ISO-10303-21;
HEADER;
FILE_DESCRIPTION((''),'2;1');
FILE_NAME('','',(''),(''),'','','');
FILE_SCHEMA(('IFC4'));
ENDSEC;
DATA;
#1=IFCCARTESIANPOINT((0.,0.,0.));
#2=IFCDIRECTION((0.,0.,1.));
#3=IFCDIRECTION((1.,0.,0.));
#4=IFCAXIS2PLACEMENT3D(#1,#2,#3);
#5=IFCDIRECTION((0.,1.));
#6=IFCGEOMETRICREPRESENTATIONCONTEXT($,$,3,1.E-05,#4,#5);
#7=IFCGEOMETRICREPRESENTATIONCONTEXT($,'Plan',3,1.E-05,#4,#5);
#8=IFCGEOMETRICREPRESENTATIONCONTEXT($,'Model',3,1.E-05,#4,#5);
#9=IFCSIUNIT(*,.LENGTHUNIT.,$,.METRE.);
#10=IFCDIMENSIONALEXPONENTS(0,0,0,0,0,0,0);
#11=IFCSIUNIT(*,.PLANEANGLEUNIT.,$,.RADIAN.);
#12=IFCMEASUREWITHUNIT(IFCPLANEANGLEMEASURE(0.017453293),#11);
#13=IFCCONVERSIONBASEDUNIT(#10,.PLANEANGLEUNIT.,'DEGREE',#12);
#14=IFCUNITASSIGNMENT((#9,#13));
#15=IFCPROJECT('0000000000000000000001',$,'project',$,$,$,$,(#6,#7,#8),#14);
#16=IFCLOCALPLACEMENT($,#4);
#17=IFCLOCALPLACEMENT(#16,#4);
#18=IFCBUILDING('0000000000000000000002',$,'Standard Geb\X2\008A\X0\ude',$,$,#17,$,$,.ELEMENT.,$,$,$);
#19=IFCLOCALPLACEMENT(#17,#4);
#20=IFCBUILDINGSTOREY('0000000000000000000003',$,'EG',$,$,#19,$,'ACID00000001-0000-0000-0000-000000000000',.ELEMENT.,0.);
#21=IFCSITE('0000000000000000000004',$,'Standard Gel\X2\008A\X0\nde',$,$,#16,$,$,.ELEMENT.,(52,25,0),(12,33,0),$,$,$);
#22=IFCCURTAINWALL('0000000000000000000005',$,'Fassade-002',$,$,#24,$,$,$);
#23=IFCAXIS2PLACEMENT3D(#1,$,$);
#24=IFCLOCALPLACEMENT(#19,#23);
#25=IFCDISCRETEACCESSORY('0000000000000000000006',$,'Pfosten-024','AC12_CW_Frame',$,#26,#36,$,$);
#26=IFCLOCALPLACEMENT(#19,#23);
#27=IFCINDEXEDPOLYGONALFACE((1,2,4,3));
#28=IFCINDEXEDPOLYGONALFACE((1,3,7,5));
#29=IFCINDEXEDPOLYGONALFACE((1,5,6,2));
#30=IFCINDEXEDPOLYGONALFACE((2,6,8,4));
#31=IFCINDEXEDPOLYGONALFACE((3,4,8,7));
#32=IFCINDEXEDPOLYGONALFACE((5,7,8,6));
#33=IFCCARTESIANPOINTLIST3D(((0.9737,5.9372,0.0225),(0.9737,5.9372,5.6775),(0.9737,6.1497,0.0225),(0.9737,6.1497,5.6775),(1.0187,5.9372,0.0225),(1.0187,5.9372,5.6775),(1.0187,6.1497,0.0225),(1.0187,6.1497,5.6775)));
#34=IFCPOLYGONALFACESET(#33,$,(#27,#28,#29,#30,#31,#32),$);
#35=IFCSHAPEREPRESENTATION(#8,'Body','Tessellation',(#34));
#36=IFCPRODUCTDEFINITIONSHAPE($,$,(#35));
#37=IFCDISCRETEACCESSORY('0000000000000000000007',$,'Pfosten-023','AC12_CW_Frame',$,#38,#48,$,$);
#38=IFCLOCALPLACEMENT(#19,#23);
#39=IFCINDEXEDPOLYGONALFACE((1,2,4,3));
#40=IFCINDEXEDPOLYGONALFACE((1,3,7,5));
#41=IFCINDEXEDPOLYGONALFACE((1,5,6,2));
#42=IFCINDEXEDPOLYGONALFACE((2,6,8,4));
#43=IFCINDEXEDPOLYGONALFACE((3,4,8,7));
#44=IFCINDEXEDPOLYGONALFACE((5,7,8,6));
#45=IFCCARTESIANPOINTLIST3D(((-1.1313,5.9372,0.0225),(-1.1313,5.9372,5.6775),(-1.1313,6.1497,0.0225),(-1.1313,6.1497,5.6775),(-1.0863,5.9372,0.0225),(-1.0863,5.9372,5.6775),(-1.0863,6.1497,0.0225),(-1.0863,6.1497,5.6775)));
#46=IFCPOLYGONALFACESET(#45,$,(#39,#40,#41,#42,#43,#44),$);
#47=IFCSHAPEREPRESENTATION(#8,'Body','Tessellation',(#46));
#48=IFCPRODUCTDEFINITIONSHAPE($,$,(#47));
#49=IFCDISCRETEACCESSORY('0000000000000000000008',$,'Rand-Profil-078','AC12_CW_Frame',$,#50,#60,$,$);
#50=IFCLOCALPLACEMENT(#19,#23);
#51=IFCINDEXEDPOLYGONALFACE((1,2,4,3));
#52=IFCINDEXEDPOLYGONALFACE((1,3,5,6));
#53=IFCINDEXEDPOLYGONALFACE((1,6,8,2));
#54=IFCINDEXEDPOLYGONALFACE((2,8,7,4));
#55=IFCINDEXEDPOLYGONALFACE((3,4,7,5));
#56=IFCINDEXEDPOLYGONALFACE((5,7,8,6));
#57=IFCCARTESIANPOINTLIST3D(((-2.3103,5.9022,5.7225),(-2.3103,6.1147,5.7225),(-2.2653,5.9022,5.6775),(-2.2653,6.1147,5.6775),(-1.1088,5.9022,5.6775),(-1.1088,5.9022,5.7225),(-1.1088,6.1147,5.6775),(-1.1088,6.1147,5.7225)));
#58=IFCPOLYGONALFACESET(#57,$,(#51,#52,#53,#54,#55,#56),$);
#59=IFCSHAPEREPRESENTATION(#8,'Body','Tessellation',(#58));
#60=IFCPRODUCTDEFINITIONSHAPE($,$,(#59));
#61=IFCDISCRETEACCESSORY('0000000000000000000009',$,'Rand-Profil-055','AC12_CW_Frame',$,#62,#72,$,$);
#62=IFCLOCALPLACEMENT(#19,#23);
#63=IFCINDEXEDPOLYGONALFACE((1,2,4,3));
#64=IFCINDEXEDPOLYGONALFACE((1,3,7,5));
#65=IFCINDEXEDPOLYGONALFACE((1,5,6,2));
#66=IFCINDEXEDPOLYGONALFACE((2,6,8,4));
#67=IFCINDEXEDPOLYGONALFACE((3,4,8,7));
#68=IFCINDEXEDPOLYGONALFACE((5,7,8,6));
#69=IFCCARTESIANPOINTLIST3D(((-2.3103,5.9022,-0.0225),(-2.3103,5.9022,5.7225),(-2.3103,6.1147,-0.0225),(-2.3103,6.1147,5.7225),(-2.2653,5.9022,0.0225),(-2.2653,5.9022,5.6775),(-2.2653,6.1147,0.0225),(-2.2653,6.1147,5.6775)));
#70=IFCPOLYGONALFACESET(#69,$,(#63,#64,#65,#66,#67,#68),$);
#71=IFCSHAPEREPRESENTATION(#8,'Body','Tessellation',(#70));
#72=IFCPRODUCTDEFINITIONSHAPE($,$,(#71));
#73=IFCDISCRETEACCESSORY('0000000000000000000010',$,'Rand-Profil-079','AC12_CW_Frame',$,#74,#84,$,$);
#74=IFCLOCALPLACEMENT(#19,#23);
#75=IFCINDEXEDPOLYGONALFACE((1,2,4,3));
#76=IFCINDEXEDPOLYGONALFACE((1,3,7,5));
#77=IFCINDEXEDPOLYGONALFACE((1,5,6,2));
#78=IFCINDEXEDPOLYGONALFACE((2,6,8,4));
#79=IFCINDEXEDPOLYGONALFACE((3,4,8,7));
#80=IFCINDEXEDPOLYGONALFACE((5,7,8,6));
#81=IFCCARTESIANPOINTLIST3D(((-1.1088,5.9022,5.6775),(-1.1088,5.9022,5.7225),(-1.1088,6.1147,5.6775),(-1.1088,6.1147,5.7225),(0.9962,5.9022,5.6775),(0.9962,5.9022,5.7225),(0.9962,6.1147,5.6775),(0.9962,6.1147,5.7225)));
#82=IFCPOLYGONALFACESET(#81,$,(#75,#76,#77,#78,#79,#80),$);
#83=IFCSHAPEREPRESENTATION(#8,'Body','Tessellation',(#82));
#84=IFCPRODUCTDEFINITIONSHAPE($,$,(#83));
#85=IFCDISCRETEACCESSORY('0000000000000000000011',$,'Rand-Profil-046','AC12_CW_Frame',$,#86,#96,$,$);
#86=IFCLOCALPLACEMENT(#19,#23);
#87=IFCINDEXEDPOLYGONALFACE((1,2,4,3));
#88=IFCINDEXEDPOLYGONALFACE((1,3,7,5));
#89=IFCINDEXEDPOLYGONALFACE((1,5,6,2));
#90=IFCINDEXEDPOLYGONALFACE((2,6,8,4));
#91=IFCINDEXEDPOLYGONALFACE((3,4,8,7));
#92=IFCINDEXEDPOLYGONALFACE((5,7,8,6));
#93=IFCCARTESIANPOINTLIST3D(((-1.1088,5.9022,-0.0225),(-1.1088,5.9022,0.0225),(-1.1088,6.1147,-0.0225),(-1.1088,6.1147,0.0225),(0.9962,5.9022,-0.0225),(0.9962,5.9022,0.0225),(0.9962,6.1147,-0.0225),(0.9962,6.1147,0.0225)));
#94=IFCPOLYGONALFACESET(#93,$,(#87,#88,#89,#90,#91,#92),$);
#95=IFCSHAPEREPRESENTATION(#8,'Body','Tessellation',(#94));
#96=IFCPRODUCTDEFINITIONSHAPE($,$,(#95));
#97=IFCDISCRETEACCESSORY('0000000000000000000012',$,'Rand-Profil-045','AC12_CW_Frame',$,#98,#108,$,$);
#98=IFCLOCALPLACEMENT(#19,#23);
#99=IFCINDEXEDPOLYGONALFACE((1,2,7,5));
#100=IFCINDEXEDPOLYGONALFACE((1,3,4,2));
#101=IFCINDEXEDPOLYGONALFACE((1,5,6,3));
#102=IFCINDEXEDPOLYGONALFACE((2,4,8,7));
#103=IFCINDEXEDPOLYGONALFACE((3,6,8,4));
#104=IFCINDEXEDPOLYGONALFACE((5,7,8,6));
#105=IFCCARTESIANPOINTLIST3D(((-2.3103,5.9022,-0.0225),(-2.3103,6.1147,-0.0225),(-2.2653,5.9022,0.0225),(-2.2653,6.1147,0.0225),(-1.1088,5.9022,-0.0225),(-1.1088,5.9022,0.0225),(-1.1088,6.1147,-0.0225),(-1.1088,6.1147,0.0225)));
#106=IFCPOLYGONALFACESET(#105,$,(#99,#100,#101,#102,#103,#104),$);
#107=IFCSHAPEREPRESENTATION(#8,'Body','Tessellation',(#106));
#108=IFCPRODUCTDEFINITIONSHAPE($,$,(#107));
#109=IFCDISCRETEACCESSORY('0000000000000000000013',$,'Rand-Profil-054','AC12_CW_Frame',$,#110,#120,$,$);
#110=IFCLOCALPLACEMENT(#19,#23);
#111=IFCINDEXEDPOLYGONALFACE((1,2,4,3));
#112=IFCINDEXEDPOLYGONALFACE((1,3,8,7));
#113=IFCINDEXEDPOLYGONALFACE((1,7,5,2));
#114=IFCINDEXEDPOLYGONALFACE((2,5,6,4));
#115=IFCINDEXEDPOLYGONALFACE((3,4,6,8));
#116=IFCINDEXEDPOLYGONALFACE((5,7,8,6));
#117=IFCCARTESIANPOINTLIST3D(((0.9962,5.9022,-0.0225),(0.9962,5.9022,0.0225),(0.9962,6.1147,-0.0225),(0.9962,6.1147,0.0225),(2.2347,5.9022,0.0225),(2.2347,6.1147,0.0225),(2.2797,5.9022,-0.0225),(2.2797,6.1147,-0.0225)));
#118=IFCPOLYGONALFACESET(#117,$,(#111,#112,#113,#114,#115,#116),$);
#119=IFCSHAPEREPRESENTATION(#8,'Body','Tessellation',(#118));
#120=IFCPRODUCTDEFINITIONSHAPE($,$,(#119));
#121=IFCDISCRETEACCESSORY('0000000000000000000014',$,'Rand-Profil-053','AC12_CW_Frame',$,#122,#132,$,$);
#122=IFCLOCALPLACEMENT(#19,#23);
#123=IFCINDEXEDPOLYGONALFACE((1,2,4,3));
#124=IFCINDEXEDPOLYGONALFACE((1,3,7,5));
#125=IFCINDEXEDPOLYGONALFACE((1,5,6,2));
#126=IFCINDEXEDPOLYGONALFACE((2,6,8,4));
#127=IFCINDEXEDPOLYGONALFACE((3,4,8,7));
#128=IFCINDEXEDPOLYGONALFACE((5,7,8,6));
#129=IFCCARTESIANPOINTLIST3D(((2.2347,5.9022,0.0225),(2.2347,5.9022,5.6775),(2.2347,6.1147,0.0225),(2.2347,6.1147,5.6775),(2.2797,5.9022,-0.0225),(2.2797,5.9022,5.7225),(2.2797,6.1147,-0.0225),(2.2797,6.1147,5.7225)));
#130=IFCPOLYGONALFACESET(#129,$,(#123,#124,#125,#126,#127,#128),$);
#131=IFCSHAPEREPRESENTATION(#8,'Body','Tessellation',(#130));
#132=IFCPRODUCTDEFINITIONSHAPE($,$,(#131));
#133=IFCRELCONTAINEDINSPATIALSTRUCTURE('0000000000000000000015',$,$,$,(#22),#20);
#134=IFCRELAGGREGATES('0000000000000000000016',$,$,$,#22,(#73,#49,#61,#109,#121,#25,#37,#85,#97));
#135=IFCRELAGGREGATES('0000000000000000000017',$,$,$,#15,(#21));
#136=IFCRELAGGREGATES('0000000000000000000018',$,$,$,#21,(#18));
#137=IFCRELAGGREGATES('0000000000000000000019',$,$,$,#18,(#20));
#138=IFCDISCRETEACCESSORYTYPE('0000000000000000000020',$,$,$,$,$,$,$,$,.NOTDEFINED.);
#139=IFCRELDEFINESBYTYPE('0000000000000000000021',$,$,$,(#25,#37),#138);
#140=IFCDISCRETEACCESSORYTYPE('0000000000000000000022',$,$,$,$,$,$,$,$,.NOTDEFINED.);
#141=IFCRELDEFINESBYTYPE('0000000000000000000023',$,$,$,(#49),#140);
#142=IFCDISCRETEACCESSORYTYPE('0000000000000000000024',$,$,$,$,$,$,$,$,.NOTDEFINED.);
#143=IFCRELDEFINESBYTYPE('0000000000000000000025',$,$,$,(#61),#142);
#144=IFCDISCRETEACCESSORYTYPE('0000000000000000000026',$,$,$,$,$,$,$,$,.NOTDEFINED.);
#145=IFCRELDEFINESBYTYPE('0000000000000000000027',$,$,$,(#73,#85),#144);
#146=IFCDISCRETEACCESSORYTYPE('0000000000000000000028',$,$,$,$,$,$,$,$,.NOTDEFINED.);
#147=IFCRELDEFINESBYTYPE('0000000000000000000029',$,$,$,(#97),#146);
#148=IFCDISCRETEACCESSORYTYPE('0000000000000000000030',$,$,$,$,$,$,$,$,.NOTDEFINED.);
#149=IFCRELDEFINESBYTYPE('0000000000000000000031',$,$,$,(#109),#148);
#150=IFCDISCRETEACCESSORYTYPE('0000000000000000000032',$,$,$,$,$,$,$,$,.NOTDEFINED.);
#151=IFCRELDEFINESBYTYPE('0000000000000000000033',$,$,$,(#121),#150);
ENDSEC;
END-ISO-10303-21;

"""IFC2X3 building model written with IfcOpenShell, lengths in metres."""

from ifc_helpers import new_model, entity, si_unit, converted_unit, direction, frame, origin_with_axes, place, context, project, spatial, polyline, outline, extrude, source, transform, mapped, type_object, type_shapes, element, aggregate, save


model = new_model("IFC2X3")

# Units and contexts
model_context = context("Model", 3, precision=1e-05, world=origin_with_axes(), true_north=direction((0.0, 1.0)))
plan_context = context("Plan", 3, precision=1e-05, world=origin_with_axes(), true_north=direction((0.0, 1.0)))
context_of_model = context(None, 3, precision=1e-05, world=origin_with_axes(), true_north=direction((0.0, 1.0)))
ifc_project = project(units=[si_unit("LENGTHUNIT", "METRE"), converted_unit("PLANEANGLEUNIT", "DEGREE", entity("IfcPlaneAngleMeasure", 0.017453293), si_unit("PLANEANGLEUNIT", "RADIAN"), dimensions=[0, 0, 0, 0, 0, 0, 0])], contexts=[context_of_model, plan_context, model_context])

# Site, building, storey
site_placement = place(None, origin_with_axes())
site = spatial("IfcSite", under=ifc_project, at=site_placement, Name="Standard Gel\u008ande", CompositionType="ELEMENT", RefLatitude=(52, 25, 0), RefLongitude=(12, 33, 0))
building_placement = place(site_placement, origin_with_axes())
building = spatial("IfcBuilding", under=site, at=building_placement, Name="Standard Geb\u008aude", CompositionType="ELEMENT")
storey_placement = place(building_placement, origin_with_axes())
storey = spatial("IfcBuildingStorey", under=building, at=storey_placement, Name="EG", LongName="ACID00000001-0000-0000-0000-000000000000", CompositionType="ELEMENT", Elevation=0.0)

# Curtain wall
curtain_wall_placement = place(storey_placement, frame((-2.2878, 5.9372, 0.0), z_axis=(0.0, 0.0, 1.0), x_axis=(1.0, 0.0, 0.0)))
curtain_wall = element("IfcCurtainWall", 1, at=curtain_wall_placement, inside=storey, Name="Fassade-002")

# Discrete accessories
discrete_accessory_type_1 = type_object("IfcDiscreteAccessoryType")
shared_shape_1 = source(origin_with_axes(), model_context, "Body", "SweptSolid", [
    extrude(outline(polyline([(0.0, 0.0), (0.2125, 0.0), (0.2125, -5.655), (0.0, -5.655), (0.0, 0.0)])), origin_with_axes(), (0.0, 0.0, 1.0), 0.045),
])
type_shapes(discrete_accessory_type_1, [shared_shape_1])
discrete_accessory_1_placement = place(storey_placement, frame((0.9737, 6.1497, 0.0225), z_axis=(1.0, 0.0, 0.0), x_axis=(0.0, -1.0, 0.0)))
discrete_accessory_1 = element("IfcDiscreteAccessory", 2, at=discrete_accessory_1_placement, type_object=discrete_accessory_type_1, Name="Pfosten-024", Description="AC12_CW_Frame", context=model_context, shape_type="MappedRepresentation", body=[
    mapped(shared_shape_1, transform((0.0, 0.0, 0.0), scale=1.0)),
])
discrete_accessory_2_placement = place(storey_placement, frame((-1.1313, 6.1497, 0.0225), z_axis=(1.0, 0.0, 0.0), x_axis=(0.0, -1.0, 0.0)))
discrete_accessory_2 = element("IfcDiscreteAccessory", 3, at=discrete_accessory_2_placement, type_object=discrete_accessory_type_1, Name="Pfosten-023", Description="AC12_CW_Frame", context=model_context, shape_type="MappedRepresentation", body=[
    mapped(shared_shape_1, transform((0.0, 0.0, 0.0), scale=1.0)),
])
discrete_accessory_type_2 = type_object("IfcDiscreteAccessoryType")
shared_shape_2 = source(origin_with_axes(), model_context, "Body", "SweptSolid", [
    extrude(outline(polyline([(0.0, 0.0), (0.0636, 0.0), (0.8814, -0.8178), (0.8496, -0.8496), (0.0, 0.0)])), origin_with_axes(), (0.0, 0.0, 1.0), 0.2125),
])
type_shapes(discrete_accessory_type_2, [shared_shape_2])
discrete_accessory_3_placement = place(storey_placement, frame((-2.3103, 5.9022, 5.7225), z_axis=(0.0, 1.0, 0.0), x_axis=(0.707107, 0.0, -0.707107)))
discrete_accessory_3 = element("IfcDiscreteAccessory", 4, at=discrete_accessory_3_placement, type_object=discrete_accessory_type_2, Name="Rand-Profil-078", Description="AC12_CW_Frame", context=model_context, shape_type="MappedRepresentation", body=[
    mapped(shared_shape_2, transform((0.0, 0.0, 0.0), scale=1.0)),
])
discrete_accessory_type_3 = type_object("IfcDiscreteAccessoryType")
shared_shape_3 = source(origin_with_axes(), model_context, "Body", "SweptSolid", [
    extrude(outline(polyline([(0.0, 0.0), (0.0636, 0.0), (4.0623, -3.9987), (4.0623, -4.0623), (0.0, 0.0)])), origin_with_axes(), (0.0, 0.0, 1.0), 0.2125),
])
type_shapes(discrete_accessory_type_3, [shared_shape_3])
discrete_accessory_4_placement = place(storey_placement, frame((-2.3103, 5.9022, -0.0225), z_axis=(0.0, 1.0, 0.0), x_axis=(0.707107, 0.0, 0.707107)))
discrete_accessory_4 = element("IfcDiscreteAccessory", 5, at=discrete_accessory_4_placement, type_object=discrete_accessory_type_3, Name="Rand-Profil-055", Description="AC12_CW_Frame", context=model_context, shape_type="MappedRepresentation", body=[
    mapped(shared_shape_3, transform((0.0, 0.0, 0.0), scale=1.0)),
])
discrete_accessory_type_4 = type_object("IfcDiscreteAccessoryType")
shared_shape_4 = source(origin_with_axes(), model_context, "Body", "SweptSolid", [
    extrude(outline(polyline([(0.0, 0.0), (0.2125, 0.0), (0.2125, -2.105), (0.0, -2.105), (0.0, 0.0)])), origin_with_axes(), (0.0, 0.0, 1.0), 0.045),
])
type_shapes(discrete_accessory_type_4, [shared_shape_4])
discrete_accessory_5_placement = place(storey_placement, frame((-1.1088, 6.1147, 5.7225), z_axis=(0.0, 0.0, -1.0), x_axis=(0.0, -1.0, 0.0)))
discrete_accessory_5 = element("IfcDiscreteAccessory", 6, at=discrete_accessory_5_placement, type_object=discrete_accessory_type_4, Name="Rand-Profil-079", Description="AC12_CW_Frame", context=model_context, shape_type="MappedRepresentation", body=[
    mapped(shared_shape_4, transform((0.0, 0.0, 0.0), scale=1.0)),
])
discrete_accessory_6_placement = place(storey_placement, frame((-1.1088, 6.1147, 0.0225), z_axis=(0.0, 0.0, -1.0), x_axis=(0.0, -1.0, 0.0)))
discrete_accessory_6 = element("IfcDiscreteAccessory", 7, at=discrete_accessory_6_placement, type_object=discrete_accessory_type_4, Name="Rand-Profil-046", Description="AC12_CW_Frame", context=model_context, shape_type="MappedRepresentation", body=[
    mapped(shared_shape_4, transform((0.0, 0.0, 0.0), scale=1.0)),
])
discrete_accessory_type_5 = type_object("IfcDiscreteAccessoryType")
shared_shape_5 = source(origin_with_axes(), model_context, "Body", "SweptSolid", [
    extrude(outline(polyline([(0.0, 0.0), (0.0636, 0.0), (-0.7859, -0.8496), (-0.8178, -0.8178), (0.0, 0.0)])), origin_with_axes(), (0.0, 0.0, 1.0), 0.2125),
])
type_shapes(discrete_accessory_type_5, [shared_shape_5])
discrete_accessory_7_placement = place(storey_placement, frame((-2.2653, 5.9022, 0.0225), z_axis=(0.0, 1.0, 0.0), x_axis=(-0.707107, 0.0, -0.707107)))
discrete_accessory_7 = element("IfcDiscreteAccessory", 8, at=discrete_accessory_7_placement, type_object=discrete_accessory_type_5, Name="Rand-Profil-045", Description="AC12_CW_Frame", context=model_context, shape_type="MappedRepresentation", body=[
    mapped(shared_shape_5, transform((0.0, 0.0, 0.0), scale=1.0)),
])
discrete_accessory_type_6 = type_object("IfcDiscreteAccessoryType")
shared_shape_6 = source(origin_with_axes(), model_context, "Body", "SweptSolid", [
    extrude(outline(polyline([(0.0, 0.0), (0.045, 0.0), (0.045, -1.2835), (0.0, -1.2385), (0.0, 0.0)])), origin_with_axes(), (0.0, 0.0, 1.0), 0.2125),
])
type_shapes(discrete_accessory_type_6, [shared_shape_6])
discrete_accessory_8_placement = place(storey_placement, frame((0.9962, 5.9022, 0.0225), z_axis=(0.0, 1.0, 0.0), x_axis=(0.0, 0.0, -1.0)))
discrete_accessory_8 = element("IfcDiscreteAccessory", 9, at=discrete_accessory_8_placement, type_object=discrete_accessory_type_6, Name="Rand-Profil-054", Description="AC12_CW_Frame", context=model_context, shape_type="MappedRepresentation", body=[
    mapped(shared_shape_6, transform((0.0, 0.0, 0.0), scale=1.0)),
])
discrete_accessory_type_7 = type_object("IfcDiscreteAccessoryType")
shared_shape_7 = source(origin_with_axes(), model_context, "Body", "SweptSolid", [
    extrude(outline(polyline([(0.0, 0.0), (0.0636, 0.0), (-3.9987, -4.0623), (-3.9987, -3.9987), (0.0, 0.0)])), origin_with_axes(), (0.0, 0.0, 1.0), 0.2125),
])
type_shapes(discrete_accessory_type_7, [shared_shape_7])
discrete_accessory_9_placement = place(storey_placement, frame((2.2347, 5.9022, 0.0225), z_axis=(0.0, 1.0, 0.0), x_axis=(0.707107, 0.0, -0.707107)))
discrete_accessory_9 = element("IfcDiscreteAccessory", 10, at=discrete_accessory_9_placement, type_object=discrete_accessory_type_7, Name="Rand-Profil-053", Description="AC12_CW_Frame", context=model_context, shape_type="MappedRepresentation", body=[
    mapped(shared_shape_7, transform((0.0, 0.0, 0.0), scale=1.0)),
])
aggregate(curtain_wall, [discrete_accessory_5, discrete_accessory_3, discrete_accessory_4, discrete_accessory_8, discrete_accessory_9, discrete_accessory_1, discrete_accessory_2, discrete_accessory_6, discrete_accessory_7])

save(model, "model.ifc")
